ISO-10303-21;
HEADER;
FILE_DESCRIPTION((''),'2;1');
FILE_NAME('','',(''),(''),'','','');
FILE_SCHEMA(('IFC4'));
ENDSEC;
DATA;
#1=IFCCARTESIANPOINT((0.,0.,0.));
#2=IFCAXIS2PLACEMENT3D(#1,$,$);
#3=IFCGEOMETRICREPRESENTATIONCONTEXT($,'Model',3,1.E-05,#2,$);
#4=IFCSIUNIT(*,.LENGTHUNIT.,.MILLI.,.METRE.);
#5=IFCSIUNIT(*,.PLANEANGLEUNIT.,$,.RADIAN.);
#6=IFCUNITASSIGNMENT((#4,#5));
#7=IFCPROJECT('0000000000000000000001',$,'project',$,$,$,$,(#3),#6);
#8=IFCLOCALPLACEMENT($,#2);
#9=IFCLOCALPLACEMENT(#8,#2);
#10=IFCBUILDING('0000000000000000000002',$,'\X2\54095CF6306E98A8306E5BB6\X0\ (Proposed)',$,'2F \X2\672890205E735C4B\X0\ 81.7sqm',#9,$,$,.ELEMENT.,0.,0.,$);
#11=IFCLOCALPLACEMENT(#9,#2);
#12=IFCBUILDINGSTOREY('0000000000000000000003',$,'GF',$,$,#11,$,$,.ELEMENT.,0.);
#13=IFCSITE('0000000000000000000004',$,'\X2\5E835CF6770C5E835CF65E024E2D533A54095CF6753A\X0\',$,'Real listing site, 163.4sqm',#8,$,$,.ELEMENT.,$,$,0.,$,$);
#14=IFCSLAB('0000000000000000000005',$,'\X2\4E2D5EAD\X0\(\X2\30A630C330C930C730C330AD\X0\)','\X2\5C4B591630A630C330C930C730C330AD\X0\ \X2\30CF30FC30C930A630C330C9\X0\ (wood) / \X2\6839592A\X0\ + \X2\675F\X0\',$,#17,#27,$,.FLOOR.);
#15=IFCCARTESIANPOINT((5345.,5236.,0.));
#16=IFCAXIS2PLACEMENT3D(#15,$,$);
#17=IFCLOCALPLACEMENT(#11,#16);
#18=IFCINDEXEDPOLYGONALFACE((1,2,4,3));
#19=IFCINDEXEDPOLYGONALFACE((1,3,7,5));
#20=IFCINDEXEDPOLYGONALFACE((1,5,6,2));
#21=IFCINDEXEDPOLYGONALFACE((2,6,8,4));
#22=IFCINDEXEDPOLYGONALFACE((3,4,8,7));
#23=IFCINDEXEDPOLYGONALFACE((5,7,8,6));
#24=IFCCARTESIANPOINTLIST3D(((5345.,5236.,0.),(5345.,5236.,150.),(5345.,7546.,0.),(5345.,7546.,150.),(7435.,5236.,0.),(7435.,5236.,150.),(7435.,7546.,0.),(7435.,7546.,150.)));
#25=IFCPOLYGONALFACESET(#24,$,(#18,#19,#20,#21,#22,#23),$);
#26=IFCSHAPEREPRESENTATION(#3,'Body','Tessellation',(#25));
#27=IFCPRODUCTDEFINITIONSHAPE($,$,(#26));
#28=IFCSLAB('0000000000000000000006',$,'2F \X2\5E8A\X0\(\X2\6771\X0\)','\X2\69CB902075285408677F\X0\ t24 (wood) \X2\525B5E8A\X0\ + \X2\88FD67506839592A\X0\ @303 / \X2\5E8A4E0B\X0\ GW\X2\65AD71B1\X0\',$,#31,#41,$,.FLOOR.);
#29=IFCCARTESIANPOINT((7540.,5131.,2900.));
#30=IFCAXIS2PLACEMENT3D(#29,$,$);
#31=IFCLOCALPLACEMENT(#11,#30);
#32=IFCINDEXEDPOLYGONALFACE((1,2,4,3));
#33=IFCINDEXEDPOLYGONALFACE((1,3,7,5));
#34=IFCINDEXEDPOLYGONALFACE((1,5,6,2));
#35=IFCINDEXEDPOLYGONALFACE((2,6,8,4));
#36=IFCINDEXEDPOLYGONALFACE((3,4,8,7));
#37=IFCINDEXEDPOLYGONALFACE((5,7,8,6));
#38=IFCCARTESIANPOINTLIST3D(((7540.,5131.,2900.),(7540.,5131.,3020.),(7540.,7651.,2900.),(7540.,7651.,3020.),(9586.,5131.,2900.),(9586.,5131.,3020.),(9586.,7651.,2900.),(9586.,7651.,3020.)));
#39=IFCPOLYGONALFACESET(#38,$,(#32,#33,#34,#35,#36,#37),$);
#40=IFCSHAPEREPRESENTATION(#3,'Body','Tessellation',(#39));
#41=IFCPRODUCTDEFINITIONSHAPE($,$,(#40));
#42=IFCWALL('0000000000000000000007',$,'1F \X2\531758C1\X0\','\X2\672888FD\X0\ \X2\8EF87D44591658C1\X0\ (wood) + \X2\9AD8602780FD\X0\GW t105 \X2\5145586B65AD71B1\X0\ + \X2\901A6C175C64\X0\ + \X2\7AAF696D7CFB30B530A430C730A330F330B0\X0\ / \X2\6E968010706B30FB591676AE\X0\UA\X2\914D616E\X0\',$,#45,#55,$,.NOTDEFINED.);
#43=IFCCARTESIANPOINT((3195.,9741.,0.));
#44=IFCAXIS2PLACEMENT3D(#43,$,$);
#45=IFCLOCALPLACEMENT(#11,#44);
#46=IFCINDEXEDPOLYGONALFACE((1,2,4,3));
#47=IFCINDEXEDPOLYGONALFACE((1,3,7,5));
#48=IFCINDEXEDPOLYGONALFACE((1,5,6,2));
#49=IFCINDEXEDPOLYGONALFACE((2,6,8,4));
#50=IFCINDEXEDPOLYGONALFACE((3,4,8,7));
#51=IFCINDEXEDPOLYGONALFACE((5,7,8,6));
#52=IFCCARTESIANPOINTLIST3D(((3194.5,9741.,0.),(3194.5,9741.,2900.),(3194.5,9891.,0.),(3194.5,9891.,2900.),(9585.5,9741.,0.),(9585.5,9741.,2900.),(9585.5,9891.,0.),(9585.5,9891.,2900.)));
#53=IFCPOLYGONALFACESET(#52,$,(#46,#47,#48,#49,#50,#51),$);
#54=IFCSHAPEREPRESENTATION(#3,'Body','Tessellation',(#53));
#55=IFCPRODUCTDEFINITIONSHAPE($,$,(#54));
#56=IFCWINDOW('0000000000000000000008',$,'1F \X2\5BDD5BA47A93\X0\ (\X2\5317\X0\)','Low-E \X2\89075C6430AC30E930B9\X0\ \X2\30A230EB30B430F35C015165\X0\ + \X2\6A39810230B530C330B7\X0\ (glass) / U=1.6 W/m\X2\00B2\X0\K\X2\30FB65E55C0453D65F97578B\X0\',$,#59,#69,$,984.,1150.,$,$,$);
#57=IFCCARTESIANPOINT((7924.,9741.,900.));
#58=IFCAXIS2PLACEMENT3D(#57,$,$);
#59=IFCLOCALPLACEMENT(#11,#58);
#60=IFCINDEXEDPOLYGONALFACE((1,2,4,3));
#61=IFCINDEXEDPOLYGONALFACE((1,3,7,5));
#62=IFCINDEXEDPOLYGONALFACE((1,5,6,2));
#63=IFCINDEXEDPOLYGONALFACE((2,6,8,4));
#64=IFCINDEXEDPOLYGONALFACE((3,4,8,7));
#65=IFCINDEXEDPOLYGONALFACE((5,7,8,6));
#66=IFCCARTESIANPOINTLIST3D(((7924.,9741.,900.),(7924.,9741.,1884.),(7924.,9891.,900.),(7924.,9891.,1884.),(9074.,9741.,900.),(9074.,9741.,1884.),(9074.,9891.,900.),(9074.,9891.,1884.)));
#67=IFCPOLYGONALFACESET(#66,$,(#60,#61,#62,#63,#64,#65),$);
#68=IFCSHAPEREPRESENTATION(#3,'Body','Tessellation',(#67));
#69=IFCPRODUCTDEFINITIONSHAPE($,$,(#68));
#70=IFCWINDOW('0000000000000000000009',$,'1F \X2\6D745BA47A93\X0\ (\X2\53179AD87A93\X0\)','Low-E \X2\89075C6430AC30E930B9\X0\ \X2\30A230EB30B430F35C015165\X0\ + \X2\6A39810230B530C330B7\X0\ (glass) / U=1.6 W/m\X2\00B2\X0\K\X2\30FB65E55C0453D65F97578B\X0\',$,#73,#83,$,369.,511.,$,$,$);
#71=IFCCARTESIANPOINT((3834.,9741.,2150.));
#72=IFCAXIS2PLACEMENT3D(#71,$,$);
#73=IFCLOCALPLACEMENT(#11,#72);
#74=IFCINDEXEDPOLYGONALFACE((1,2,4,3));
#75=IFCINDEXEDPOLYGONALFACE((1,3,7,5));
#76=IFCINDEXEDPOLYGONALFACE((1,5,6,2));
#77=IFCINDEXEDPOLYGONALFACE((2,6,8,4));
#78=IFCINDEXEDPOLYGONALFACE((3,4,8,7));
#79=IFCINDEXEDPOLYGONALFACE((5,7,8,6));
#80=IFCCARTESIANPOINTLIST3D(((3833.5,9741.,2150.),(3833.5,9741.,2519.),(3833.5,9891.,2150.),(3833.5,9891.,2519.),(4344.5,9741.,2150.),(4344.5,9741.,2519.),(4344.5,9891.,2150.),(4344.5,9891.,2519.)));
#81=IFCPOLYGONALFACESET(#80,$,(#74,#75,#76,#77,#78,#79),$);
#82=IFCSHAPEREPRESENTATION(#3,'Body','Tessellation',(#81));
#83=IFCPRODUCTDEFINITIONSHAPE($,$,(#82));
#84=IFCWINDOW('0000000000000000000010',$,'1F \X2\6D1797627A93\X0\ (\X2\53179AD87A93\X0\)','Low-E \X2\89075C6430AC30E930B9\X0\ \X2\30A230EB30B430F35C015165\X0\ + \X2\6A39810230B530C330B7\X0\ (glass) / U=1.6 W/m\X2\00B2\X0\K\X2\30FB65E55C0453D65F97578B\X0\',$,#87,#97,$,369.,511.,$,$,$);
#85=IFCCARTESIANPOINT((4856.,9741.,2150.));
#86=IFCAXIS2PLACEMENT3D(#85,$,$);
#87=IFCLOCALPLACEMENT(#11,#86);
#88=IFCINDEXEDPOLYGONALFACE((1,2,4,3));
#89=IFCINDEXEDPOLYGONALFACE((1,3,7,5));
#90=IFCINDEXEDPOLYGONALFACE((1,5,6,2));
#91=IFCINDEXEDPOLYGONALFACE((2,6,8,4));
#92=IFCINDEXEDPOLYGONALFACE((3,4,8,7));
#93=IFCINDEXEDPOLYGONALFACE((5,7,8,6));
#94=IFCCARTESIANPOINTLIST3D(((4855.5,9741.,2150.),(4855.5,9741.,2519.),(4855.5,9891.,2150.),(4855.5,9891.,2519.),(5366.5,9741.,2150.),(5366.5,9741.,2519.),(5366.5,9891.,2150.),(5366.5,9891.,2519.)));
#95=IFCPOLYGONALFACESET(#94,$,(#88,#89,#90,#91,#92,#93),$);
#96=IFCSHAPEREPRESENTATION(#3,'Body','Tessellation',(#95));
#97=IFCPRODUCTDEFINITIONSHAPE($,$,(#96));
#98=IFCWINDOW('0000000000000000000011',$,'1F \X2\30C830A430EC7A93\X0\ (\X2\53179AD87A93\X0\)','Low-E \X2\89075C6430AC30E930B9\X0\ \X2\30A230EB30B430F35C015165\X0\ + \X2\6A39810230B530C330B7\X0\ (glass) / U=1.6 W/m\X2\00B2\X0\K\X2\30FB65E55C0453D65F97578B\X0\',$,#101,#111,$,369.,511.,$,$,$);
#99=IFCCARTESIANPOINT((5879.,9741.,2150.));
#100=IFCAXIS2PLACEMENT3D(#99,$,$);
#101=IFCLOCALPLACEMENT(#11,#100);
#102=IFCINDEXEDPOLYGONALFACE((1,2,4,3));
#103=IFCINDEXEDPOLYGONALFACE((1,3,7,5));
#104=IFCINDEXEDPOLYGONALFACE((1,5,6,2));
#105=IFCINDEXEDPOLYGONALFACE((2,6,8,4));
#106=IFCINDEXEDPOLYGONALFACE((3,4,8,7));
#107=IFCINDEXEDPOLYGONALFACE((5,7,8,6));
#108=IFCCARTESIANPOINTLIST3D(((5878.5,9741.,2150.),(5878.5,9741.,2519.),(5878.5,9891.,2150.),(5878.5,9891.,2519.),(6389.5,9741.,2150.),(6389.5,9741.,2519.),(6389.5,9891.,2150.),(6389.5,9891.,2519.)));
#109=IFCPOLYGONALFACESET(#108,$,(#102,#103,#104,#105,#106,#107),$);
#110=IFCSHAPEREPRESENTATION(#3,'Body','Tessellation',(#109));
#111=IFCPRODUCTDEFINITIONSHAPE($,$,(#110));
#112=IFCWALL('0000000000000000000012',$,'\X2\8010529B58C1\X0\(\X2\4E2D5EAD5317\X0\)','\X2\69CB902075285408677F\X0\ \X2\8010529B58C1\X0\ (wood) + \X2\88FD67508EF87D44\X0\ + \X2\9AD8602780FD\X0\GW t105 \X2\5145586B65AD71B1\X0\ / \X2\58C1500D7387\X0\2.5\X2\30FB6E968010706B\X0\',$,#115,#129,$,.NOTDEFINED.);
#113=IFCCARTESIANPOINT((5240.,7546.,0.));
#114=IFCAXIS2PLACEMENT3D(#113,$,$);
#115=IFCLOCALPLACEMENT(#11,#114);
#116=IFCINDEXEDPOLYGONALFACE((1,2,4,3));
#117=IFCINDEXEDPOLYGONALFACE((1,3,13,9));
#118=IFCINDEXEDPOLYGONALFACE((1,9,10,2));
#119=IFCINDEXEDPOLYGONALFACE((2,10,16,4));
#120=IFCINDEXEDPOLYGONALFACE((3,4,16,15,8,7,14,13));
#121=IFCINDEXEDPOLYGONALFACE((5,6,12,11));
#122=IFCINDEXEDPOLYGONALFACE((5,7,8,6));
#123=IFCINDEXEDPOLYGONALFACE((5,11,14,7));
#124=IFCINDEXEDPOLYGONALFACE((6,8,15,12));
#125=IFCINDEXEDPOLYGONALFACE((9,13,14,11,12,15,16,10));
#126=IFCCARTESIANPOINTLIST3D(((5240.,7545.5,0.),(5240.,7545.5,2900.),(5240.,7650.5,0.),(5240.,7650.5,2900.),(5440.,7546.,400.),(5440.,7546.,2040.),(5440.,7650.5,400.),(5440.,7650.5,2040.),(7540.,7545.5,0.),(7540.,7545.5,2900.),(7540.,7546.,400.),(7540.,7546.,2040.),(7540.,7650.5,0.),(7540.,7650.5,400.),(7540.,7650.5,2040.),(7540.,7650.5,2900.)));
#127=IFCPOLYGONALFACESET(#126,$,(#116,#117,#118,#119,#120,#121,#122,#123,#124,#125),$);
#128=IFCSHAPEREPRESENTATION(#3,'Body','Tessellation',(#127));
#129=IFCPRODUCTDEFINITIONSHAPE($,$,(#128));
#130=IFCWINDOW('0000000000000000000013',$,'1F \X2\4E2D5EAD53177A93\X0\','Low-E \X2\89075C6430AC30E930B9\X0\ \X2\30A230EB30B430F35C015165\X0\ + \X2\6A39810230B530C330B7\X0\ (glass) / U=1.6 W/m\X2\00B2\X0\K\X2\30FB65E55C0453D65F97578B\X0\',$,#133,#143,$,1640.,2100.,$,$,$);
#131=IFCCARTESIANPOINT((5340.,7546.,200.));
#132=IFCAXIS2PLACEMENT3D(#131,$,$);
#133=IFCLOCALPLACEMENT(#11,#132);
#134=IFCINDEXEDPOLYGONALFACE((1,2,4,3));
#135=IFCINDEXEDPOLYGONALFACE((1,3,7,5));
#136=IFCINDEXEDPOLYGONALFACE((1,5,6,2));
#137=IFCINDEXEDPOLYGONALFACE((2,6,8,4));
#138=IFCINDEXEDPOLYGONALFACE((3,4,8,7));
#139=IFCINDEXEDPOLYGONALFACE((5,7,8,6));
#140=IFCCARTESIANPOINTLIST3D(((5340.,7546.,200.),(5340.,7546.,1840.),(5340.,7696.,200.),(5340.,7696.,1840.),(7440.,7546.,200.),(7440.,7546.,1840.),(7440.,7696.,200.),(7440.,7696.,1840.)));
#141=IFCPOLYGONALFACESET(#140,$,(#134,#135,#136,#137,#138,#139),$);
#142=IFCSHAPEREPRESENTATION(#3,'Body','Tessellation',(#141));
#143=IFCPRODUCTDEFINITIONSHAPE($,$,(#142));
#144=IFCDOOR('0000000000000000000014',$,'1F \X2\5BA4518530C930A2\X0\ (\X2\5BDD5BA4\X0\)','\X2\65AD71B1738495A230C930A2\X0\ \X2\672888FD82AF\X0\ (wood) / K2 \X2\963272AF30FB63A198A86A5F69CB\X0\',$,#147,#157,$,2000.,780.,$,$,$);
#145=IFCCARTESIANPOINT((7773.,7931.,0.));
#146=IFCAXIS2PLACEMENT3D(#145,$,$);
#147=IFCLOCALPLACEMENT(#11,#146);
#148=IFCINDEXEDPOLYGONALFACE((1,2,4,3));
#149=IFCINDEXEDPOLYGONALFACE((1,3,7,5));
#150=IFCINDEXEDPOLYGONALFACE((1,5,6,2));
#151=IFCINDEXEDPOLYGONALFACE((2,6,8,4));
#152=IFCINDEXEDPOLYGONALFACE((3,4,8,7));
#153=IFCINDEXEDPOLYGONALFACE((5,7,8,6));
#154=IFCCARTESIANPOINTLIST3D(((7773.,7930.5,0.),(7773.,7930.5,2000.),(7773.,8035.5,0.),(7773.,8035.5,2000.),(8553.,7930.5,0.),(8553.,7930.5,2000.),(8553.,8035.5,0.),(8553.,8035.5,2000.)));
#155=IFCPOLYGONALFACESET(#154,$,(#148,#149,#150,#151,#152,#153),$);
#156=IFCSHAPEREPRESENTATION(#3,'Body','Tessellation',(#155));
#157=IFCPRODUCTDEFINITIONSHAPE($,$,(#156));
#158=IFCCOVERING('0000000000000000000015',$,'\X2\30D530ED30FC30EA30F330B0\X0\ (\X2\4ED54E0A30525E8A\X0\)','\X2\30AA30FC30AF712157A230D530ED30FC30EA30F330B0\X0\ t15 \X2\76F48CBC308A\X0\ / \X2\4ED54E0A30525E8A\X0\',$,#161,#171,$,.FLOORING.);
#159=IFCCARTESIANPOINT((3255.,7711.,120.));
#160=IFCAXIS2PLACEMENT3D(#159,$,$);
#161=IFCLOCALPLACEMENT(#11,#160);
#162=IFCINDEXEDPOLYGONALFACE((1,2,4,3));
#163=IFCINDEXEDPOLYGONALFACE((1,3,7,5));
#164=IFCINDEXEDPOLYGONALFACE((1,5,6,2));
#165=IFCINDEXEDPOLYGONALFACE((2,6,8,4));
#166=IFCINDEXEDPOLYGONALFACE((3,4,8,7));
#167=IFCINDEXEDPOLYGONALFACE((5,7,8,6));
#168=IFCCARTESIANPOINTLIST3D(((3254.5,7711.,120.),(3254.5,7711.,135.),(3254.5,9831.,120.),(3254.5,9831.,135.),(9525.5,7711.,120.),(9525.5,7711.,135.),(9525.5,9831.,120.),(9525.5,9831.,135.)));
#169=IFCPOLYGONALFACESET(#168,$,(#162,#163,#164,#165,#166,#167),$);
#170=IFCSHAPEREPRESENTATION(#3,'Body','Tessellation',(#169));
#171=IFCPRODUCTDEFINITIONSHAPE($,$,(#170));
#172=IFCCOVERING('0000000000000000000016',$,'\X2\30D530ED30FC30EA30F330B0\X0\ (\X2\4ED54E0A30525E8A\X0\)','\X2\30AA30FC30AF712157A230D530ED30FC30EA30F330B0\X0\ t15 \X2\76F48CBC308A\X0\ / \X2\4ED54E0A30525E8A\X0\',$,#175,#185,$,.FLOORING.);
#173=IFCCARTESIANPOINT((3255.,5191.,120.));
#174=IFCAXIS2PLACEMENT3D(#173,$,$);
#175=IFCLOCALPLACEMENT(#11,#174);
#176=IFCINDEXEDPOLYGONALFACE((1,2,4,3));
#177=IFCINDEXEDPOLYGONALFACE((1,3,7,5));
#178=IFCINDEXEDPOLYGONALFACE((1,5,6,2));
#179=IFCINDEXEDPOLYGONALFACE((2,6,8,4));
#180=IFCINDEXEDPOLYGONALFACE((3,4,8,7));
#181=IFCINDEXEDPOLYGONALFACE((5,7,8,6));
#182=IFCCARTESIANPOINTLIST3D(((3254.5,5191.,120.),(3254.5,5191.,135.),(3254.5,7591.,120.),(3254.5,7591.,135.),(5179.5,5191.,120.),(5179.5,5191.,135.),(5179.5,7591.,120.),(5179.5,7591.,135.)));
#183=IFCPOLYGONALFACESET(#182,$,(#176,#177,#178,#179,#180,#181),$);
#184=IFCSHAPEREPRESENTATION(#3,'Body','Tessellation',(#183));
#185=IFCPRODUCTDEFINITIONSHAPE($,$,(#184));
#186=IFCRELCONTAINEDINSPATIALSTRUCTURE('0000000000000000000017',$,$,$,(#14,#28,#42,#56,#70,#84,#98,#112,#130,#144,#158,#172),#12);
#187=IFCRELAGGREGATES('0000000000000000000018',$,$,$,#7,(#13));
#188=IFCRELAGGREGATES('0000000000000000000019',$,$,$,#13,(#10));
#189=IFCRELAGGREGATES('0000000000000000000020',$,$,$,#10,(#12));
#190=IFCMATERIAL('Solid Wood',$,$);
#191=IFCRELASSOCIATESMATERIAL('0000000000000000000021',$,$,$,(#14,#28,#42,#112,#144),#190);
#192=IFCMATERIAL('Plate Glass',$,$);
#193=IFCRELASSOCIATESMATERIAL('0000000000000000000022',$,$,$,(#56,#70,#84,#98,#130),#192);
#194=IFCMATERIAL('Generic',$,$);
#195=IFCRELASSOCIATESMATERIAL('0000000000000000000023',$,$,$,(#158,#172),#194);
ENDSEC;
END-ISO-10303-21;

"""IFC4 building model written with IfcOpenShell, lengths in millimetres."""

from ifc_helpers import new_model, si_unit, frame, frame_2d, origin, place, context, project, spatial, rectangle, extrude, material, element, fill, save


model = new_model("IFC4")

# Units and contexts
model_context = context("Model", 3, precision=1e-05, world=origin())
ifc_project = project(units=[si_unit("LENGTHUNIT", "METRE", prefix="MILLI"), si_unit("PLANEANGLEUNIT", "RADIAN")], contexts=[model_context])

# Site, building, storey
site_placement = place(None, origin())
site = spatial("IfcSite", under=ifc_project, at=site_placement, Name="広島県広島市中区吉島町", ObjectType="Real listing site, 163.4sqm", CompositionType="ELEMENT", RefElevation=0.0)
building_placement = place(site_placement, origin())
building = spatial("IfcBuilding", under=site, at=building_placement, Name="吉島の風の家 (Proposed)", ObjectType="2F 木造平屋 81.7sqm", CompositionType="ELEMENT", ElevationOfRefHeight=0.0, ElevationOfTerrain=0.0)
storey_placement = place(building_placement, origin())
storey = spatial("IfcBuildingStorey", under=building, at=storey_placement, Name="GF", CompositionType="ELEMENT", Elevation=0.0)

# Slabs
ifc_material_1 = material(Name="Solid Wood")
slab_1_placement = place(storey_placement, frame((5345.0, 5236.0, 0.0)))
element("IfcSlab", 1, at=slab_1_placement, inside=storey, material=ifc_material_1, Name="中庭(ウッドデッキ)", Description="屋外ウッドデッキ ハードウッド (wood) / 根太 + 束", PredefinedType="FLOOR", context=model_context, shape_type="SweptSolid", body=[
    extrude(rectangle(XDim=2090.0, YDim=2310.0, at=frame_2d((1045.0, 1155.0))), frame((5345.0, 5236.0, 0.0)), (0.0, 0.0, 1.0), 150.0),
])
slab_2_placement = place(storey_placement, frame((7540.0, 5131.0, 2900.0)))
element("IfcSlab", 2, at=slab_2_placement, inside=storey, material=ifc_material_1, Name="2F 床(東)", Description="構造用合板 t24 (wood) 剛床 + 製材根太 @303 / 床下 GW断熱", PredefinedType="FLOOR", context=model_context, shape_type="SweptSolid", body=[
    extrude(rectangle(XDim=2046.0, YDim=2520.0, at=frame_2d((1023.0, 1260.0))), frame((7540.0, 5131.0, 2900.0)), (0.0, 0.0, 1.0), 120.0),
])

# Wall, openings, windows
wall_1_placement = place(storey_placement, frame((3195.0, 9741.0, 0.0)))
wall_1 = element("IfcWall", 3, at=wall_1_placement, inside=storey, material=ifc_material_1, Name="1F 北壁", Description="木製 軸組外壁 (wood) + 高性能GW t105 充填断熱 + 通気層 + 窯業系サイディング / 準耐火・外皮UA配慮", PredefinedType="NOTDEFINED", context=model_context, shape_type="SweptSolid", body=[
    extrude(rectangle(XDim=6391.0, YDim=150.0, at=frame_2d((3195.0, 75.0))), frame((3195.0, 9741.0, 0.0)), (0.0, 0.0, 1.0), 2900.0),
])
opening_1_placement = place(storey_placement, frame((7924.0, 9741.0, 900.0)))
opening_1 = element("IfcOpeningElement", 4, at=opening_1_placement, cuts=wall_1, PredefinedType="NOTDEFINED", context=model_context, shape_type="SweptSolid", body=[
    extrude(rectangle(XDim=1150.0, YDim=150.0, at=frame_2d((575.0, 75.0))), frame((7924.0, 9741.0, 900.0)), (0.0, 0.0, 1.0), 984.0),
])
opening_2_placement = place(storey_placement, frame((3834.0, 9741.0, 2150.0)))
opening_2 = element("IfcOpeningElement", 5, at=opening_2_placement, cuts=wall_1, PredefinedType="NOTDEFINED", context=model_context, shape_type="SweptSolid", body=[
    extrude(rectangle(XDim=511.0, YDim=150.0, at=frame_2d((255.0, 75.0))), frame((3834.0, 9741.0, 2150.0)), (0.0, 0.0, 1.0), 369.0),
])
opening_3_placement = place(storey_placement, frame((4856.0, 9741.0, 2150.0)))
opening_3 = element("IfcOpeningElement", 6, at=opening_3_placement, cuts=wall_1, PredefinedType="NOTDEFINED", context=model_context, shape_type="SweptSolid", body=[
    extrude(rectangle(XDim=511.0, YDim=150.0, at=frame_2d((255.0, 75.0))), frame((4856.0, 9741.0, 2150.0)), (0.0, 0.0, 1.0), 369.0),
])
opening_4_placement = place(storey_placement, frame((5879.0, 9741.0, 2150.0)))
opening_4 = element("IfcOpeningElement", 7, at=opening_4_placement, cuts=wall_1, PredefinedType="NOTDEFINED", context=model_context, shape_type="SweptSolid", body=[
    extrude(rectangle(XDim=511.0, YDim=150.0, at=frame_2d((255.0, 75.0))), frame((5879.0, 9741.0, 2150.0)), (0.0, 0.0, 1.0), 369.0),
])
ifc_material_2 = material(Name="Plate Glass")
window_1_placement = place(storey_placement, frame((7924.0, 9741.0, 900.0)))
window_1 = element("IfcWindow", 8, at=window_1_placement, inside=storey, material=ifc_material_2, Name="1F 寝室窓 (北)", Description="Low-E 複層ガラス アルゴン封入 + 樹脂サッシ (glass) / U=1.6 W/m²K・日射取得型", OverallHeight=984.0, OverallWidth=1150.0, context=model_context, shape_type="SweptSolid", body=[
    extrude(rectangle(XDim=1150.0, YDim=150.0, at=frame_2d((575.0, 75.0))), frame((7924.0, 9741.0, 900.0)), (0.0, 0.0, 1.0), 984.0),
])
fill(opening_1, window_1)
window_2_placement = place(storey_placement, frame((3834.0, 9741.0, 2150.0)))
window_2 = element("IfcWindow", 9, at=window_2_placement, inside=storey, material=ifc_material_2, Name="1F 浴室窓 (北高窓)", Description="Low-E 複層ガラス アルゴン封入 + 樹脂サッシ (glass) / U=1.6 W/m²K・日射取得型", OverallHeight=369.0, OverallWidth=511.0, context=model_context, shape_type="SweptSolid", body=[
    extrude(rectangle(XDim=511.0, YDim=150.0, at=frame_2d((255.0, 75.0))), frame((3834.0, 9741.0, 2150.0)), (0.0, 0.0, 1.0), 369.0),
])
fill(opening_2, window_2)
window_3_placement = place(storey_placement, frame((4856.0, 9741.0, 2150.0)))
window_3 = element("IfcWindow", 10, at=window_3_placement, inside=storey, material=ifc_material_2, Name="1F 洗面窓 (北高窓)", Description="Low-E 複層ガラス アルゴン封入 + 樹脂サッシ (glass) / U=1.6 W/m²K・日射取得型", OverallHeight=369.0, OverallWidth=511.0, context=model_context, shape_type="SweptSolid", body=[
    extrude(rectangle(XDim=511.0, YDim=150.0, at=frame_2d((255.0, 75.0))), frame((4856.0, 9741.0, 2150.0)), (0.0, 0.0, 1.0), 369.0),
])
fill(opening_3, window_3)
window_4_placement = place(storey_placement, frame((5879.0, 9741.0, 2150.0)))
window_4 = element("IfcWindow", 11, at=window_4_placement, inside=storey, material=ifc_material_2, Name="1F トイレ窓 (北高窓)", Description="Low-E 複層ガラス アルゴン封入 + 樹脂サッシ (glass) / U=1.6 W/m²K・日射取得型", OverallHeight=369.0, OverallWidth=511.0, context=model_context, shape_type="SweptSolid", body=[
    extrude(rectangle(XDim=511.0, YDim=150.0, at=frame_2d((255.0, 75.0))), frame((5879.0, 9741.0, 2150.0)), (0.0, 0.0, 1.0), 369.0),
])
fill(opening_4, window_4)

# Wall, opening, window
wall_2_placement = place(storey_placement, frame((5240.0, 7546.0, 0.0)))
wall_2 = element("IfcWall", 12, at=wall_2_placement, inside=storey, material=ifc_material_1, Name="耐力壁(中庭北)", Description="構造用合板 耐力壁 (wood) + 製材軸組 + 高性能GW t105 充填断熱 / 壁倍率2.5・準耐火", PredefinedType="NOTDEFINED", context=model_context, shape_type="SweptSolid", body=[
    extrude(rectangle(XDim=2300.0, YDim=105.0, at=frame_2d((1150.0, 52.0))), frame((5240.0, 7546.0, 0.0)), (0.0, 0.0, 1.0), 2900.0),
])
opening_5_placement = place(storey_placement, frame((5340.0, 7546.0, 200.0)))
opening_5 = element("IfcOpeningElement", 13, at=opening_5_placement, cuts=wall_2, PredefinedType="NOTDEFINED", context=model_context, shape_type="SweptSolid", body=[
    extrude(rectangle(XDim=2100.0, YDim=150.0, at=frame_2d((1050.0, 75.0))), frame((5340.0, 7546.0, 200.0)), (0.0, 0.0, 1.0), 1640.0),
])
window_5_placement = place(storey_placement, frame((5340.0, 7546.0, 200.0)))
window_5 = element("IfcWindow", 14, at=window_5_placement, inside=storey, material=ifc_material_2, Name="1F 中庭北窓", Description="Low-E 複層ガラス アルゴン封入 + 樹脂サッシ (glass) / U=1.6 W/m²K・日射取得型", OverallHeight=1640.0, OverallWidth=2100.0, context=model_context, shape_type="SweptSolid", body=[
    extrude(rectangle(XDim=2100.0, YDim=150.0, at=frame_2d((1050.0, 75.0))), frame((5340.0, 7546.0, 200.0)), (0.0, 0.0, 1.0), 1640.0),
])
fill(opening_5, window_5)

# Door
door_1_placement = place(storey_placement, frame((7773.0, 7931.0, 0.0)))
element("IfcDoor", 15, at=door_1_placement, inside=storey, material=ifc_material_1, Name="1F 室内ドア (寝室)", Description="断熱玄関ドア 木製芯 (wood) / K2 防犯・採風機構", OverallHeight=2000.0, OverallWidth=780.0, context=model_context, shape_type="SweptSolid", body=[
    extrude(rectangle(XDim=780.0, YDim=105.0, at=frame_2d((390.0, 52.0))), frame((7773.0, 7931.0, 0.0)), (0.0, 0.0, 1.0), 2000.0),
])

# Coverings
ifc_material_3 = material(Name="Generic")
covering_1_placement = place(storey_placement, frame((3255.0, 7711.0, 120.0)))
element("IfcCovering", 16, at=covering_1_placement, inside=storey, material=ifc_material_3, Name="フローリング (仕上げ床)", Description="オーク無垢フローリング t15 直貼り / 仕上げ床", PredefinedType="FLOORING", context=model_context, shape_type="SweptSolid", body=[
    extrude(rectangle(XDim=6271.0, YDim=2120.0, at=frame_2d((3135.0, 1060.0))), frame((3255.0, 7711.0, 120.0)), (0.0, 0.0, 1.0), 15.0),
])
covering_2_placement = place(storey_placement, frame((3255.0, 5191.0, 120.0)))
element("IfcCovering", 17, at=covering_2_placement, inside=storey, material=ifc_material_3, Name="フローリング (仕上げ床)", Description="オーク無垢フローリング t15 直貼り / 仕上げ床", PredefinedType="FLOORING", context=model_context, shape_type="SweptSolid", body=[
    extrude(rectangle(XDim=1925.0, YDim=2400.0, at=frame_2d((962.0, 1200.0))), frame((3255.0, 5191.0, 120.0)), (0.0, 0.0, 1.0), 15.0),
])

save(model, "model.ifc")
